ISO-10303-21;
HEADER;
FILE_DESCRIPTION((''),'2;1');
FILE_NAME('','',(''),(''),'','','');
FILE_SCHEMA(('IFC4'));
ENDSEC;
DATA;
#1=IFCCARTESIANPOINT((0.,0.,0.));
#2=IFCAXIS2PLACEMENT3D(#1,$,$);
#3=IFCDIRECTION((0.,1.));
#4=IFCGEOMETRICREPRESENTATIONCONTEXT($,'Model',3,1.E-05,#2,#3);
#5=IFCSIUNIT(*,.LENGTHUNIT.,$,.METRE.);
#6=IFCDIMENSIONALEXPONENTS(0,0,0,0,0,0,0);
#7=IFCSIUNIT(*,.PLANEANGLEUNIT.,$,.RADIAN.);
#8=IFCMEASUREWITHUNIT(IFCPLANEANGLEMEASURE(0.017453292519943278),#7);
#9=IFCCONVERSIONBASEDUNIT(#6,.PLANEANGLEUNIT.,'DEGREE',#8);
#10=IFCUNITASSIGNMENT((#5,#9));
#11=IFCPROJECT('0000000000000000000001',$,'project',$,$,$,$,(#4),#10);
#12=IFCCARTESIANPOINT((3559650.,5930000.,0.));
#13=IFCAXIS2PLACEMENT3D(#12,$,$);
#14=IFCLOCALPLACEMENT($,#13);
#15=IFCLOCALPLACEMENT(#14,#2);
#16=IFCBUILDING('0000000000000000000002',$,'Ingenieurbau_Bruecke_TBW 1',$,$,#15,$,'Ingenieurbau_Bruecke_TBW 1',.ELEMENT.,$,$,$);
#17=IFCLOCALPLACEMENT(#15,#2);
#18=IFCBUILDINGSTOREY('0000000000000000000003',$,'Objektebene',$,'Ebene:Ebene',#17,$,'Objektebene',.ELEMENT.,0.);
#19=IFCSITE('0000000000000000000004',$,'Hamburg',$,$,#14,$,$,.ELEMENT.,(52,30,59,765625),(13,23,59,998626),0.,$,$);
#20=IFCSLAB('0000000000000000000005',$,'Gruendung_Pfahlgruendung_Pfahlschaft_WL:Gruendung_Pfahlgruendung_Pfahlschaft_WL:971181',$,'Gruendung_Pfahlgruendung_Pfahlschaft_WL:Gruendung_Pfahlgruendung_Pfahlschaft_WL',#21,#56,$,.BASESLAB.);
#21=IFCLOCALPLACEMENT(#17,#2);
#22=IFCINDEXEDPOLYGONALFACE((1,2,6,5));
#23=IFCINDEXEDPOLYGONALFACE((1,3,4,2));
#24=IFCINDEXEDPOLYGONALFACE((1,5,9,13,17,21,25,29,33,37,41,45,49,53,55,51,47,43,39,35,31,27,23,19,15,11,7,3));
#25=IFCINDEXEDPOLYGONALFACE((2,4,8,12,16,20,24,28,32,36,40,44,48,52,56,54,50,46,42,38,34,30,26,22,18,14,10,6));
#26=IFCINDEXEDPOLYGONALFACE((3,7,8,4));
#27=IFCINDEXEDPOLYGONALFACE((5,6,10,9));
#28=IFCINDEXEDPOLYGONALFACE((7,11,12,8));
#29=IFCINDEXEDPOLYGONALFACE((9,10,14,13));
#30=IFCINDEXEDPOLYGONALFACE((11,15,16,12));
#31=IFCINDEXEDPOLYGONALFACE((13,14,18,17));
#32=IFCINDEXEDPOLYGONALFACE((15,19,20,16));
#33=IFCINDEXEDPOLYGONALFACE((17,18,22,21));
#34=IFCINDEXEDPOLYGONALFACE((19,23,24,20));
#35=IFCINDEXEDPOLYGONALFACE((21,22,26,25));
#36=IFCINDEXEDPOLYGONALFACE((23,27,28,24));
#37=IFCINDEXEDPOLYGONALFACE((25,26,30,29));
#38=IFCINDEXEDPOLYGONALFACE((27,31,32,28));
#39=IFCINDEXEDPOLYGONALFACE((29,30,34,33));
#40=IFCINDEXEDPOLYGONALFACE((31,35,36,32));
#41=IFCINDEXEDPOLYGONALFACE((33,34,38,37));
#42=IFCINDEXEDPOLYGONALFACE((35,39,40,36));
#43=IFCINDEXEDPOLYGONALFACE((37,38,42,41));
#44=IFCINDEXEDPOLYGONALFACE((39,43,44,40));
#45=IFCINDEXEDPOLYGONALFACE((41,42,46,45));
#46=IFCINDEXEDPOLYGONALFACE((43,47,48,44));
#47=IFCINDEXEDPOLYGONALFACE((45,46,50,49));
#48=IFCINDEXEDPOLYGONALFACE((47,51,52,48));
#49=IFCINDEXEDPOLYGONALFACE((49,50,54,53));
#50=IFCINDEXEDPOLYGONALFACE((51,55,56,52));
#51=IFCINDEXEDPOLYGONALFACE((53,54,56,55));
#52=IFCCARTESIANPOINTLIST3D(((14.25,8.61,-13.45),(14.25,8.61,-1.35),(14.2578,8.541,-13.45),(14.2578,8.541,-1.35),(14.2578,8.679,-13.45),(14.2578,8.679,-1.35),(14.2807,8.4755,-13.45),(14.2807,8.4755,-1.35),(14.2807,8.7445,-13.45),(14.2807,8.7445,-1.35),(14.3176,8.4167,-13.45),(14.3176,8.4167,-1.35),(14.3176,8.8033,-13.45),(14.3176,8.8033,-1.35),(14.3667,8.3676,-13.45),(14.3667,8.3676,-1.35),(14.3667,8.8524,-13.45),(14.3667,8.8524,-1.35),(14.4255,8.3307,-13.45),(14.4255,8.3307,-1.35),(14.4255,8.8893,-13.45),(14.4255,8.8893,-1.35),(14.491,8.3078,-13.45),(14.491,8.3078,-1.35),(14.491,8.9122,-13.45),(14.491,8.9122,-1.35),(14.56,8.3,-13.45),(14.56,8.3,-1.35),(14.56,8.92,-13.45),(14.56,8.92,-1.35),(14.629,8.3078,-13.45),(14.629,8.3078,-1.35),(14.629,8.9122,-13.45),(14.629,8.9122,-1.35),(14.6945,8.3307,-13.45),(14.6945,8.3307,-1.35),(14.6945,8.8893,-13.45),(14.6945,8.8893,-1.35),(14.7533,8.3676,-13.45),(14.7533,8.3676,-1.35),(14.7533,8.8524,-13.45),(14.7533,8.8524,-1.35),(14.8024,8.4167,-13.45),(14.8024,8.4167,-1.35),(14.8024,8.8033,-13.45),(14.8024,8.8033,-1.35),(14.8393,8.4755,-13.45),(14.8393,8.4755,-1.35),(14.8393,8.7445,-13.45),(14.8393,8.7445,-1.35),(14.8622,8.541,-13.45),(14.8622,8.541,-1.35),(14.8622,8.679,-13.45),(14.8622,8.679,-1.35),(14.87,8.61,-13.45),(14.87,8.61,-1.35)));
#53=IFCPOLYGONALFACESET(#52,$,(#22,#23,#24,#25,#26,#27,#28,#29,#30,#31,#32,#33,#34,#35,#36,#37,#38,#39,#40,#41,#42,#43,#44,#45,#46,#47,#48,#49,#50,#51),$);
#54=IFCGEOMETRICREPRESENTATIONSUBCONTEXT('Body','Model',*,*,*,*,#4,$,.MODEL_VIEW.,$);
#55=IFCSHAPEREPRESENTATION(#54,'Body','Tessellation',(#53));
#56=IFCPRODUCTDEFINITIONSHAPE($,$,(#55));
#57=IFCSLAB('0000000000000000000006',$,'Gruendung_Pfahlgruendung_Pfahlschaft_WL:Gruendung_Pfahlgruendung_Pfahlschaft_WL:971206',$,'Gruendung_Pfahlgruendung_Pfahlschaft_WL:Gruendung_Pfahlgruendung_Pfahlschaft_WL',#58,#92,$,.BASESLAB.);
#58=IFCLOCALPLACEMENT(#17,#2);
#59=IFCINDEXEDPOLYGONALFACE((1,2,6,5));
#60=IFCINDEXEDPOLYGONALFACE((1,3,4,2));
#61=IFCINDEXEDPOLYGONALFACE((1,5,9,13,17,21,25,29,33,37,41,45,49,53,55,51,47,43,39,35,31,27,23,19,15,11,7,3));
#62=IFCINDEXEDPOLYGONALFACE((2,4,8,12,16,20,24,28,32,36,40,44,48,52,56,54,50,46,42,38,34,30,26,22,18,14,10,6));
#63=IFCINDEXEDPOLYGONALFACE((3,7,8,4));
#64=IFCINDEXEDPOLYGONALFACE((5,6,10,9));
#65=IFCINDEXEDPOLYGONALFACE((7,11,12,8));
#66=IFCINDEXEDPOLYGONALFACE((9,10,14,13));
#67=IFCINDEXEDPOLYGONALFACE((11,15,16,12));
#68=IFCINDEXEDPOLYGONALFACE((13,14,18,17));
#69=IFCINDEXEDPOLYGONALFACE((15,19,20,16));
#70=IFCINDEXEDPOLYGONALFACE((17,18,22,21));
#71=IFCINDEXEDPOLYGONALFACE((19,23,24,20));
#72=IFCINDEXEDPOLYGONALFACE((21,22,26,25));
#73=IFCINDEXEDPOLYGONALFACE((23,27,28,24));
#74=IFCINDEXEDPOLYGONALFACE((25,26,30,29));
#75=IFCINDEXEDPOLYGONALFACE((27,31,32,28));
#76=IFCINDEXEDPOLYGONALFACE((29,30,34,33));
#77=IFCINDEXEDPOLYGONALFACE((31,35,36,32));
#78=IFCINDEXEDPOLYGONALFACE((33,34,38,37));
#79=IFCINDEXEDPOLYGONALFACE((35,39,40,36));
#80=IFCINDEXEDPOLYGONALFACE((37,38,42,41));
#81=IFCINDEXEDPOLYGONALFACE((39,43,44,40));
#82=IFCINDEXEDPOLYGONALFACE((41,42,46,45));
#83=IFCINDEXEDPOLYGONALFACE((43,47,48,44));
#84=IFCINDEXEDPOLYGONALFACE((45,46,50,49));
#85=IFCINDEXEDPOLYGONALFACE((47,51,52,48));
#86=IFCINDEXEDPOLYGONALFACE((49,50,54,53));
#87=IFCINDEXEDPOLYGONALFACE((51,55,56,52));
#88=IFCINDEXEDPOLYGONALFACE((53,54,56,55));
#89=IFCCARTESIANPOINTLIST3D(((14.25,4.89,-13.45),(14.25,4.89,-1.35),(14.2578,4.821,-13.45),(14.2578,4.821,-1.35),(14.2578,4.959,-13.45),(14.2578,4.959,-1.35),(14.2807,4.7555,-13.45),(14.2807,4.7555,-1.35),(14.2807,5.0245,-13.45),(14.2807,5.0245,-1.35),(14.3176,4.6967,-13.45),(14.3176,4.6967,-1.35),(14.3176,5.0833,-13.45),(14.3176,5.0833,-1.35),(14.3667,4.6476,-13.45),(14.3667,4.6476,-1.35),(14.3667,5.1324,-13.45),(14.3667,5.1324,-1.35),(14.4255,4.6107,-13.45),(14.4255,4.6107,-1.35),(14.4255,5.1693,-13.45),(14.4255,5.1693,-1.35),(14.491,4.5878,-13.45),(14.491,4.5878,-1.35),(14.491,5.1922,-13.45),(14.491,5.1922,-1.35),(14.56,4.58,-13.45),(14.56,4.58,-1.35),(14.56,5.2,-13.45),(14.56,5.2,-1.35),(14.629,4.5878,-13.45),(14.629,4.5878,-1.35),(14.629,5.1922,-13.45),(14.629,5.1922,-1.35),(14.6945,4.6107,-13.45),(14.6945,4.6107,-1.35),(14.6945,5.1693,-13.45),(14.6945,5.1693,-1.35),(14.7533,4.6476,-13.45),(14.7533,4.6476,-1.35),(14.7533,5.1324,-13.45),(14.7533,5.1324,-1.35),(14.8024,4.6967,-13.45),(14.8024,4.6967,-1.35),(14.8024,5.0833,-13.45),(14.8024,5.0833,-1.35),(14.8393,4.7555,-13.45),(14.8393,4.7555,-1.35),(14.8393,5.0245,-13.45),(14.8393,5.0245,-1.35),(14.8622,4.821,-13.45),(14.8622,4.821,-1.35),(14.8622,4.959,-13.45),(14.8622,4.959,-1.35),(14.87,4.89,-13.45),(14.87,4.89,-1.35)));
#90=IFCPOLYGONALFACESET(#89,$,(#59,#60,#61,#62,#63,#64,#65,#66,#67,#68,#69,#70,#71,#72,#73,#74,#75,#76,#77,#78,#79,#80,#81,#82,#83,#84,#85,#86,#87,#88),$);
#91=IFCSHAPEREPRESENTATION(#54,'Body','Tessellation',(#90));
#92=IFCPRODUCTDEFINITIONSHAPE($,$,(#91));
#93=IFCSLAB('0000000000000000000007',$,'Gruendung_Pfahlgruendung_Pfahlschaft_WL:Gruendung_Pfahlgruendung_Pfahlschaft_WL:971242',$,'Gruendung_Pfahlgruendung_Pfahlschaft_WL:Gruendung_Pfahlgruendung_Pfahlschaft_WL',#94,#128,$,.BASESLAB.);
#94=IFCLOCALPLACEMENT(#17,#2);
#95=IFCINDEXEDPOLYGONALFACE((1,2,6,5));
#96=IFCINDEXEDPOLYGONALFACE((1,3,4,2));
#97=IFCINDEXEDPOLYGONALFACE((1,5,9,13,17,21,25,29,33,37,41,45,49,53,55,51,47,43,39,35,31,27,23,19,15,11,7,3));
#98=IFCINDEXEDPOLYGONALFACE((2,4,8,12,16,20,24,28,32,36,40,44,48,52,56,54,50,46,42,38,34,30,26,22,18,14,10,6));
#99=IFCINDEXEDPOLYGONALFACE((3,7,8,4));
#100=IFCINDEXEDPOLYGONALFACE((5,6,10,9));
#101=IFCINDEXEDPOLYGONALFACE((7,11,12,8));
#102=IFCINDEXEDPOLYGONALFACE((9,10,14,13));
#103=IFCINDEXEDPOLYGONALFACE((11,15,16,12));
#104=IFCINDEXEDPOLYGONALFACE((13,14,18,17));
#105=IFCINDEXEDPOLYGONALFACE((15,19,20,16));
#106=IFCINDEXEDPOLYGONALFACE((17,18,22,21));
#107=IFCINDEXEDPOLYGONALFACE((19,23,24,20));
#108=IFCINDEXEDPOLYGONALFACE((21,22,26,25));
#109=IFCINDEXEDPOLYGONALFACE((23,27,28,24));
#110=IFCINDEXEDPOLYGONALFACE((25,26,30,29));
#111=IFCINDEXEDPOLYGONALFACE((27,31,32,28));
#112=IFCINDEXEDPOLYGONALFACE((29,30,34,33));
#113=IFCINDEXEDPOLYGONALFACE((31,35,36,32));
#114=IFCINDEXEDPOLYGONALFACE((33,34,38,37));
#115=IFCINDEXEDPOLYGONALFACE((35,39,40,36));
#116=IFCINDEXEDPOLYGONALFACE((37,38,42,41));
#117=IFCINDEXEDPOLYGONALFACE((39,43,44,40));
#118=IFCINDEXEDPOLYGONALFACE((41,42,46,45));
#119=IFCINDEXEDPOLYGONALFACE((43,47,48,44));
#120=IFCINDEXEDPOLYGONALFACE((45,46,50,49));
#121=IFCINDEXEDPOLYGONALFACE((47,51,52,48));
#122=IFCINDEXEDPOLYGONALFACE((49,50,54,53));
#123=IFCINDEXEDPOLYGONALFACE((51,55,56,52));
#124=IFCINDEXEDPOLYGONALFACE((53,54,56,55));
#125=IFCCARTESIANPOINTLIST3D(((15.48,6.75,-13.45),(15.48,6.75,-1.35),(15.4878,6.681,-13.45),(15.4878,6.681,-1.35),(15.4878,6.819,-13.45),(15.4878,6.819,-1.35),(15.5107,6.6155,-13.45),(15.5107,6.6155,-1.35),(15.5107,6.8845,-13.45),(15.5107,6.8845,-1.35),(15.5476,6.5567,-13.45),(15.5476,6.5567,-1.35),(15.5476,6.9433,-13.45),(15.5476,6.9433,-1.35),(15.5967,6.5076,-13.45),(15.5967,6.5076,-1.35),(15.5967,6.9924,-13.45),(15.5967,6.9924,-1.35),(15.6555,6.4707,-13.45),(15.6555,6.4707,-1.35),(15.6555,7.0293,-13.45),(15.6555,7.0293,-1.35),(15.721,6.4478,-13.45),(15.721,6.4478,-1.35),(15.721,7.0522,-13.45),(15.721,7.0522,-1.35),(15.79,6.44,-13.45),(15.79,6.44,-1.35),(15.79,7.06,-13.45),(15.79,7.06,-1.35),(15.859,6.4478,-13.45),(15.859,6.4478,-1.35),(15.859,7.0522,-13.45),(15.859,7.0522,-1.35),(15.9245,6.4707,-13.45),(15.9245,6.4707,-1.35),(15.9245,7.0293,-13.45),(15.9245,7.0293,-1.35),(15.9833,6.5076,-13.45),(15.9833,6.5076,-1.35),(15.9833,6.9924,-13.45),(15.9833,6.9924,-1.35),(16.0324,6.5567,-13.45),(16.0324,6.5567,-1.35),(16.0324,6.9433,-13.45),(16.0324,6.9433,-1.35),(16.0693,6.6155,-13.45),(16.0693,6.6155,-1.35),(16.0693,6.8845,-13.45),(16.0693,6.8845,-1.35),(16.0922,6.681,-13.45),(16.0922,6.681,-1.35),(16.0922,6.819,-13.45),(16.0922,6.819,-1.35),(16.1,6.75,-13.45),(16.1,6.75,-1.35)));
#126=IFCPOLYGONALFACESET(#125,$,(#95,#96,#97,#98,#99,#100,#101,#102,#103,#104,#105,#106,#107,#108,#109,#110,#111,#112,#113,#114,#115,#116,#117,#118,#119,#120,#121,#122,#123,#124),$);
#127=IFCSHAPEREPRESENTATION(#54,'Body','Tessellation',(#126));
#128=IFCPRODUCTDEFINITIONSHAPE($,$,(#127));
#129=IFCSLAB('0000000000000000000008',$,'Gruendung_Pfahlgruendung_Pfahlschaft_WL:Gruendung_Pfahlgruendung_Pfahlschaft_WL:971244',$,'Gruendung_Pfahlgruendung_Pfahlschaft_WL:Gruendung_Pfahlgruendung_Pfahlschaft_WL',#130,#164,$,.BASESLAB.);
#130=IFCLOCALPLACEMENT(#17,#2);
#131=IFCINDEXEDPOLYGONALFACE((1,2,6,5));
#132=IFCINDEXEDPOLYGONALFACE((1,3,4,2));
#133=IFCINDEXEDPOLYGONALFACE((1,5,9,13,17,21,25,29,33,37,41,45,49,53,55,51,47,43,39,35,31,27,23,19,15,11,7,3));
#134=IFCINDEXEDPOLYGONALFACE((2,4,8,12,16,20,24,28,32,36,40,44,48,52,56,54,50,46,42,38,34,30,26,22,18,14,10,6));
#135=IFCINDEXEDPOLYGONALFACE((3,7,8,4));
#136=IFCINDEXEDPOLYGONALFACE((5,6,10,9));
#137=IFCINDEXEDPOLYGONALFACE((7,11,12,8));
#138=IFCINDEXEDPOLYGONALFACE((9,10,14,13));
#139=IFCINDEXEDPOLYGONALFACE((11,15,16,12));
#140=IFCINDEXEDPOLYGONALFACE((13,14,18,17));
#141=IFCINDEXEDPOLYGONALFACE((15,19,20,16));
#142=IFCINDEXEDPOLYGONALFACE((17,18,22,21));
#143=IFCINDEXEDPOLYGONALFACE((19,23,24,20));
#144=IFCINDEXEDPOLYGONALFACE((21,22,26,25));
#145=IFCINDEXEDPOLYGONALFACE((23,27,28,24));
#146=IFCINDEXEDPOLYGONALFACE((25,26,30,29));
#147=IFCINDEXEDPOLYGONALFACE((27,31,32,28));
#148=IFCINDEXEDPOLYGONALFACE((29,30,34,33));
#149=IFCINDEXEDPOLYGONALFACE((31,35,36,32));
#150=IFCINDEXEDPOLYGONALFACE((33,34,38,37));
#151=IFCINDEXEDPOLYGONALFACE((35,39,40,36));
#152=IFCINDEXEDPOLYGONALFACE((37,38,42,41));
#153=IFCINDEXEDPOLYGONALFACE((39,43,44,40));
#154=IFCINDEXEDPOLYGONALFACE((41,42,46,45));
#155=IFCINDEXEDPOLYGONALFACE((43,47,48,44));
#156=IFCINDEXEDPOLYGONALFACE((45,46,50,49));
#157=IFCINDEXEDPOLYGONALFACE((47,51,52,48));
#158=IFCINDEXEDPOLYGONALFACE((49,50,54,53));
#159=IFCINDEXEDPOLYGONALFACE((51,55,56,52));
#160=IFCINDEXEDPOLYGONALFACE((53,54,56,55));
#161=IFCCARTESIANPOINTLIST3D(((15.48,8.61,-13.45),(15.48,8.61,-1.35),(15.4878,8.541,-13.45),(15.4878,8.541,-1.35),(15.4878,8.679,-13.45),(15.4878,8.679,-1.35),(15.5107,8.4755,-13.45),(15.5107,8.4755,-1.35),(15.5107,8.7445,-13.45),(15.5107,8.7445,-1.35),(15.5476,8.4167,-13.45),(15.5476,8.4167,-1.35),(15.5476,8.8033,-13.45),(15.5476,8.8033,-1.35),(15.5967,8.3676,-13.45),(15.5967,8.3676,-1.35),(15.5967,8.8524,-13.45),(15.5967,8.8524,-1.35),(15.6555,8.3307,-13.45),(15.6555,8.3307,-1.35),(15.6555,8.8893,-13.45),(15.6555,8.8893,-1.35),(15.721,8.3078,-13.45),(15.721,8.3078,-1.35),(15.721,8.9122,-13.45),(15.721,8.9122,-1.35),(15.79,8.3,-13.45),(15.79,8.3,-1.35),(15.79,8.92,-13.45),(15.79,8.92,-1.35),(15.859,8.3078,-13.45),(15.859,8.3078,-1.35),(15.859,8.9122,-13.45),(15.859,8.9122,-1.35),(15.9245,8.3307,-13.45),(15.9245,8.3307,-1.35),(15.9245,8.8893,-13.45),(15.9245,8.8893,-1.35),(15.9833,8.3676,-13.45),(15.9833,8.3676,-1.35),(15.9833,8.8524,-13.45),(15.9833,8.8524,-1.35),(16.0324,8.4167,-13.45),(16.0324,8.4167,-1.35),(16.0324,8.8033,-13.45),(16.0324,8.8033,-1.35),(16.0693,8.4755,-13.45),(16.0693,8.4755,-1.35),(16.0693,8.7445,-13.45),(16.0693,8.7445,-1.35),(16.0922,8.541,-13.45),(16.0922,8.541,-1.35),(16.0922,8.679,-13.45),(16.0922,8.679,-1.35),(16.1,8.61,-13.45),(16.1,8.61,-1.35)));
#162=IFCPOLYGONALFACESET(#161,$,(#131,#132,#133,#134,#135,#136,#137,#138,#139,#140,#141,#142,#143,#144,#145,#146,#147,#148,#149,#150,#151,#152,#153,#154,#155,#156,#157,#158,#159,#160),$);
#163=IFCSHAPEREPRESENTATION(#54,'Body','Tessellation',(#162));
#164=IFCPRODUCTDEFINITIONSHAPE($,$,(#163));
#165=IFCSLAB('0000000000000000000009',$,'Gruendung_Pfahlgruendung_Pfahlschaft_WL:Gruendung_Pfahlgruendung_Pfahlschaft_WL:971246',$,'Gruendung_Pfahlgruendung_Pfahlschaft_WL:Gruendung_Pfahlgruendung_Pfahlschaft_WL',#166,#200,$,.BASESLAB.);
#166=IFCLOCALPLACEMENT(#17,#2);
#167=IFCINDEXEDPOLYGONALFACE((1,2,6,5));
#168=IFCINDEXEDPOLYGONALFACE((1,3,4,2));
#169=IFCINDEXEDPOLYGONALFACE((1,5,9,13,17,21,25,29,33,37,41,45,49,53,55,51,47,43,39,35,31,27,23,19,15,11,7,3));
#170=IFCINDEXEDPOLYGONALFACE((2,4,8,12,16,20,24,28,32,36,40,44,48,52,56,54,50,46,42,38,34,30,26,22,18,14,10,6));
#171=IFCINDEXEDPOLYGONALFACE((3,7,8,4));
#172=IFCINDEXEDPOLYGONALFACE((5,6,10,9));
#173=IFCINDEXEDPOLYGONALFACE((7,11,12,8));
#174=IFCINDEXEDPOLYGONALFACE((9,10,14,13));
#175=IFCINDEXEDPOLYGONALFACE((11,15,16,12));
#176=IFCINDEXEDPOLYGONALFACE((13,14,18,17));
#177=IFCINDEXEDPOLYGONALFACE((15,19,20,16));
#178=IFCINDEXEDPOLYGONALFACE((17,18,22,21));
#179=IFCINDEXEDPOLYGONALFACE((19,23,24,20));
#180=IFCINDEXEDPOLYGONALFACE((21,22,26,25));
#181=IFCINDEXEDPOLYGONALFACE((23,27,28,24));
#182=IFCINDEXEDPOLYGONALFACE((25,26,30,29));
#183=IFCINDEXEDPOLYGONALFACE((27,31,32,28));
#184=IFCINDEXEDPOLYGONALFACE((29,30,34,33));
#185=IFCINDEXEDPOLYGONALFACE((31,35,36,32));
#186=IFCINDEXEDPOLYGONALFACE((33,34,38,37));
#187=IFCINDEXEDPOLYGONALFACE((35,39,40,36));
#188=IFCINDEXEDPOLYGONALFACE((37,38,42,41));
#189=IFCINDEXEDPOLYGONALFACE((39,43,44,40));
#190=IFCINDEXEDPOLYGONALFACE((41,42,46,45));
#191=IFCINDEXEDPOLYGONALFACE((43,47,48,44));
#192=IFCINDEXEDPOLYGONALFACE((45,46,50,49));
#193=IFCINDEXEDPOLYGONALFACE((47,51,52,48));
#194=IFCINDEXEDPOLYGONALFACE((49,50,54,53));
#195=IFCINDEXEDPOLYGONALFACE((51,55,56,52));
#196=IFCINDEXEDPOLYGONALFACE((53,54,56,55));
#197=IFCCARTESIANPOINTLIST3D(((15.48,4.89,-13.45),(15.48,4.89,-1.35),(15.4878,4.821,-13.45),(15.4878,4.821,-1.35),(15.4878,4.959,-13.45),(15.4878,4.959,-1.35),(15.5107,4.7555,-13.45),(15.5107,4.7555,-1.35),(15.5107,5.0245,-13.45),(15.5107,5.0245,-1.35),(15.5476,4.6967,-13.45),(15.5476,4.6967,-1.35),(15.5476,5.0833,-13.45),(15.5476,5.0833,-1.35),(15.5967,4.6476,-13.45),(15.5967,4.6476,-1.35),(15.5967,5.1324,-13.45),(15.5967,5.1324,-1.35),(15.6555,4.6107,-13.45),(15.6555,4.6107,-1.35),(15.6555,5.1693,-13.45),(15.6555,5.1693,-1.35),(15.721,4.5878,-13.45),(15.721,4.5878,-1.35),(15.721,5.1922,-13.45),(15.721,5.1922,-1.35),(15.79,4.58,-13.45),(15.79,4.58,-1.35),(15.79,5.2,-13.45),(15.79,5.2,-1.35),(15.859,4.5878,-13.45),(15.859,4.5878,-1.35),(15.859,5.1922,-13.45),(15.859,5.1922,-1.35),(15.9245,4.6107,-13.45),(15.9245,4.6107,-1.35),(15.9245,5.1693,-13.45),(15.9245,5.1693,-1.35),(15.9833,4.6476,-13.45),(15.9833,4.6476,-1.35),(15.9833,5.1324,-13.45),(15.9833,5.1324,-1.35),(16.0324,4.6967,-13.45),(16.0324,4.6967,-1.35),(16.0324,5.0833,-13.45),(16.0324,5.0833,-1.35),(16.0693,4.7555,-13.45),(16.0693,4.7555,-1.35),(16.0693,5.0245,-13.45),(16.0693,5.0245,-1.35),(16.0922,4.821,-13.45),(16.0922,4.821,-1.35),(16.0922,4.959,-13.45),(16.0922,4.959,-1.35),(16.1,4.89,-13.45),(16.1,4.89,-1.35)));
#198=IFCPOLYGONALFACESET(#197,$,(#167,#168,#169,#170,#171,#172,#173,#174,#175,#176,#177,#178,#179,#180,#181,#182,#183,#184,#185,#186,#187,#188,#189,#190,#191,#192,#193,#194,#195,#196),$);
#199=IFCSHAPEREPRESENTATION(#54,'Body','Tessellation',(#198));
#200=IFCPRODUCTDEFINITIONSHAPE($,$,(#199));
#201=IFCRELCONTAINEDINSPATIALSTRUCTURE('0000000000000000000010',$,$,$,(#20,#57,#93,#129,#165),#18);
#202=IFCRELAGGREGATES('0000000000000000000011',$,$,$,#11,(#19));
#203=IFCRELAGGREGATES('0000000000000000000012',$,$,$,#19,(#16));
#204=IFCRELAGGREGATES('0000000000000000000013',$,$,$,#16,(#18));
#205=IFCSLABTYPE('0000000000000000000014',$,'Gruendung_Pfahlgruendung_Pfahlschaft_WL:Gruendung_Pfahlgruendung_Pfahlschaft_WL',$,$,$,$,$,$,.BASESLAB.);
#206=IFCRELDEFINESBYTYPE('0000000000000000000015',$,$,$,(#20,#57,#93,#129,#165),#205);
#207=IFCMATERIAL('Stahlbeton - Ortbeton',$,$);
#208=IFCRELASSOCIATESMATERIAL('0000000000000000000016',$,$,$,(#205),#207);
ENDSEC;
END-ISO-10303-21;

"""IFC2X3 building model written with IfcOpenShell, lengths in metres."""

from ifc_helpers import new_model, entity, si_unit, converted_unit, direction, frame, frame_2d, origin, origin_2d_with_axis, place, context, subcontext, project, spatial, circle, extrude, material, type_object, element, save


model = new_model("IFC2X3")

# Units and contexts
model_context = context("Model", 3, precision=1e-05, world=origin(), true_north=direction((0.0, 1.0)))
body_context = subcontext(model_context, "Body", "Model", "MODEL_VIEW")
ifc_project = project(units=[si_unit("LENGTHUNIT", "METRE"), converted_unit("PLANEANGLEUNIT", "DEGREE", entity("IfcPlaneAngleMeasure", 0.017453292519943278), si_unit("PLANEANGLEUNIT", "RADIAN"), dimensions=[0, 0, 0, 0, 0, 0, 0])], contexts=[model_context])

# Site, building, storey
site_placement = place(None, frame((3559650.0, 5930000.0, 0.0)))
site = spatial("IfcSite", under=ifc_project, at=site_placement, Name="Hamburg", CompositionType="ELEMENT", RefLatitude=(52, 30, 59, 765625), RefLongitude=(13, 23, 59, 998626), RefElevation=0.0)
building_placement = place(site_placement, origin())
building = spatial("IfcBuilding", under=site, at=building_placement, Name="Ingenieurbau_Bruecke_TBW 1", LongName="Ingenieurbau_Bruecke_TBW 1", CompositionType="ELEMENT")
storey_placement = place(building_placement, origin())
storey = spatial("IfcBuildingStorey", under=building, at=storey_placement, Name="Objektebene", ObjectType="Ebene:Ebene", LongName="Objektebene", CompositionType="ELEMENT", Elevation=0.0)

# Slabs
ifc_material_1 = material(Name="Stahlbeton - Ortbeton")
slab_type_1 = type_object("IfcSlabType", Name="Gruendung_Pfahlgruendung_Pfahlschaft_WL:Gruendung_Pfahlgruendung_Pfahlschaft_WL", PredefinedType="BASESLAB", material=ifc_material_1)
slab_1_placement = place(storey_placement, origin())
element("IfcSlab", 1, at=slab_1_placement, inside=storey, type_object=slab_type_1, Name="Gruendung_Pfahlgruendung_Pfahlschaft_WL:Gruendung_Pfahlgruendung_Pfahlschaft_WL:971181", ObjectType="Gruendung_Pfahlgruendung_Pfahlschaft_WL:Gruendung_Pfahlgruendung_Pfahlschaft_WL", PredefinedType="BASESLAB", context=body_context, shape_type="SweptSolid", body=[
    extrude(circle(Radius=0.31, at=frame_2d((0.0, 0.0), x_axis=(1.0, 0.0))), frame((14.56, 8.61, -13.45)), (0.0, 0.0, 1.0), 12.1),
])
slab_2_placement = place(storey_placement, origin())
element("IfcSlab", 2, at=slab_2_placement, inside=storey, type_object=slab_type_1, Name="Gruendung_Pfahlgruendung_Pfahlschaft_WL:Gruendung_Pfahlgruendung_Pfahlschaft_WL:971206", ObjectType="Gruendung_Pfahlgruendung_Pfahlschaft_WL:Gruendung_Pfahlgruendung_Pfahlschaft_WL", PredefinedType="BASESLAB", context=body_context, shape_type="SweptSolid", body=[
    extrude(circle(Radius=0.31, at=origin_2d_with_axis()), frame((14.56, 4.89, -13.45)), (0.0, 0.0, 1.0), 12.1),
])
slab_3_placement = place(storey_placement, origin())
element("IfcSlab", 3, at=slab_3_placement, inside=storey, type_object=slab_type_1, Name="Gruendung_Pfahlgruendung_Pfahlschaft_WL:Gruendung_Pfahlgruendung_Pfahlschaft_WL:971242", ObjectType="Gruendung_Pfahlgruendung_Pfahlschaft_WL:Gruendung_Pfahlgruendung_Pfahlschaft_WL", PredefinedType="BASESLAB", context=body_context, shape_type="SweptSolid", body=[
    extrude(circle(Radius=0.31, at=frame_2d((0.0, 0.0), x_axis=(1.0, 0.0))), frame((15.79, 6.75, -13.45)), (0.0, 0.0, 1.0), 12.1),
])
slab_4_placement = place(storey_placement, origin())
element("IfcSlab", 4, at=slab_4_placement, inside=storey, type_object=slab_type_1, Name="Gruendung_Pfahlgruendung_Pfahlschaft_WL:Gruendung_Pfahlgruendung_Pfahlschaft_WL:971244", ObjectType="Gruendung_Pfahlgruendung_Pfahlschaft_WL:Gruendung_Pfahlgruendung_Pfahlschaft_WL", PredefinedType="BASESLAB", context=body_context, shape_type="SweptSolid", body=[
    extrude(circle(Radius=0.31, at=frame_2d((0.0, 0.0), x_axis=(1.0, 0.0))), frame((15.79, 8.61, -13.45)), (0.0, 0.0, 1.0), 12.1),
])
slab_5_placement = place(storey_placement, origin())
element("IfcSlab", 5, at=slab_5_placement, inside=storey, type_object=slab_type_1, Name="Gruendung_Pfahlgruendung_Pfahlschaft_WL:Gruendung_Pfahlgruendung_Pfahlschaft_WL:971246", ObjectType="Gruendung_Pfahlgruendung_Pfahlschaft_WL:Gruendung_Pfahlgruendung_Pfahlschaft_WL", PredefinedType="BASESLAB", context=body_context, shape_type="SweptSolid", body=[
    extrude(circle(Radius=0.31, at=origin_2d_with_axis()), frame((15.79, 4.89, -13.45)), (0.0, 0.0, 1.0), 12.1),
])

save(model, "model.ifc")
